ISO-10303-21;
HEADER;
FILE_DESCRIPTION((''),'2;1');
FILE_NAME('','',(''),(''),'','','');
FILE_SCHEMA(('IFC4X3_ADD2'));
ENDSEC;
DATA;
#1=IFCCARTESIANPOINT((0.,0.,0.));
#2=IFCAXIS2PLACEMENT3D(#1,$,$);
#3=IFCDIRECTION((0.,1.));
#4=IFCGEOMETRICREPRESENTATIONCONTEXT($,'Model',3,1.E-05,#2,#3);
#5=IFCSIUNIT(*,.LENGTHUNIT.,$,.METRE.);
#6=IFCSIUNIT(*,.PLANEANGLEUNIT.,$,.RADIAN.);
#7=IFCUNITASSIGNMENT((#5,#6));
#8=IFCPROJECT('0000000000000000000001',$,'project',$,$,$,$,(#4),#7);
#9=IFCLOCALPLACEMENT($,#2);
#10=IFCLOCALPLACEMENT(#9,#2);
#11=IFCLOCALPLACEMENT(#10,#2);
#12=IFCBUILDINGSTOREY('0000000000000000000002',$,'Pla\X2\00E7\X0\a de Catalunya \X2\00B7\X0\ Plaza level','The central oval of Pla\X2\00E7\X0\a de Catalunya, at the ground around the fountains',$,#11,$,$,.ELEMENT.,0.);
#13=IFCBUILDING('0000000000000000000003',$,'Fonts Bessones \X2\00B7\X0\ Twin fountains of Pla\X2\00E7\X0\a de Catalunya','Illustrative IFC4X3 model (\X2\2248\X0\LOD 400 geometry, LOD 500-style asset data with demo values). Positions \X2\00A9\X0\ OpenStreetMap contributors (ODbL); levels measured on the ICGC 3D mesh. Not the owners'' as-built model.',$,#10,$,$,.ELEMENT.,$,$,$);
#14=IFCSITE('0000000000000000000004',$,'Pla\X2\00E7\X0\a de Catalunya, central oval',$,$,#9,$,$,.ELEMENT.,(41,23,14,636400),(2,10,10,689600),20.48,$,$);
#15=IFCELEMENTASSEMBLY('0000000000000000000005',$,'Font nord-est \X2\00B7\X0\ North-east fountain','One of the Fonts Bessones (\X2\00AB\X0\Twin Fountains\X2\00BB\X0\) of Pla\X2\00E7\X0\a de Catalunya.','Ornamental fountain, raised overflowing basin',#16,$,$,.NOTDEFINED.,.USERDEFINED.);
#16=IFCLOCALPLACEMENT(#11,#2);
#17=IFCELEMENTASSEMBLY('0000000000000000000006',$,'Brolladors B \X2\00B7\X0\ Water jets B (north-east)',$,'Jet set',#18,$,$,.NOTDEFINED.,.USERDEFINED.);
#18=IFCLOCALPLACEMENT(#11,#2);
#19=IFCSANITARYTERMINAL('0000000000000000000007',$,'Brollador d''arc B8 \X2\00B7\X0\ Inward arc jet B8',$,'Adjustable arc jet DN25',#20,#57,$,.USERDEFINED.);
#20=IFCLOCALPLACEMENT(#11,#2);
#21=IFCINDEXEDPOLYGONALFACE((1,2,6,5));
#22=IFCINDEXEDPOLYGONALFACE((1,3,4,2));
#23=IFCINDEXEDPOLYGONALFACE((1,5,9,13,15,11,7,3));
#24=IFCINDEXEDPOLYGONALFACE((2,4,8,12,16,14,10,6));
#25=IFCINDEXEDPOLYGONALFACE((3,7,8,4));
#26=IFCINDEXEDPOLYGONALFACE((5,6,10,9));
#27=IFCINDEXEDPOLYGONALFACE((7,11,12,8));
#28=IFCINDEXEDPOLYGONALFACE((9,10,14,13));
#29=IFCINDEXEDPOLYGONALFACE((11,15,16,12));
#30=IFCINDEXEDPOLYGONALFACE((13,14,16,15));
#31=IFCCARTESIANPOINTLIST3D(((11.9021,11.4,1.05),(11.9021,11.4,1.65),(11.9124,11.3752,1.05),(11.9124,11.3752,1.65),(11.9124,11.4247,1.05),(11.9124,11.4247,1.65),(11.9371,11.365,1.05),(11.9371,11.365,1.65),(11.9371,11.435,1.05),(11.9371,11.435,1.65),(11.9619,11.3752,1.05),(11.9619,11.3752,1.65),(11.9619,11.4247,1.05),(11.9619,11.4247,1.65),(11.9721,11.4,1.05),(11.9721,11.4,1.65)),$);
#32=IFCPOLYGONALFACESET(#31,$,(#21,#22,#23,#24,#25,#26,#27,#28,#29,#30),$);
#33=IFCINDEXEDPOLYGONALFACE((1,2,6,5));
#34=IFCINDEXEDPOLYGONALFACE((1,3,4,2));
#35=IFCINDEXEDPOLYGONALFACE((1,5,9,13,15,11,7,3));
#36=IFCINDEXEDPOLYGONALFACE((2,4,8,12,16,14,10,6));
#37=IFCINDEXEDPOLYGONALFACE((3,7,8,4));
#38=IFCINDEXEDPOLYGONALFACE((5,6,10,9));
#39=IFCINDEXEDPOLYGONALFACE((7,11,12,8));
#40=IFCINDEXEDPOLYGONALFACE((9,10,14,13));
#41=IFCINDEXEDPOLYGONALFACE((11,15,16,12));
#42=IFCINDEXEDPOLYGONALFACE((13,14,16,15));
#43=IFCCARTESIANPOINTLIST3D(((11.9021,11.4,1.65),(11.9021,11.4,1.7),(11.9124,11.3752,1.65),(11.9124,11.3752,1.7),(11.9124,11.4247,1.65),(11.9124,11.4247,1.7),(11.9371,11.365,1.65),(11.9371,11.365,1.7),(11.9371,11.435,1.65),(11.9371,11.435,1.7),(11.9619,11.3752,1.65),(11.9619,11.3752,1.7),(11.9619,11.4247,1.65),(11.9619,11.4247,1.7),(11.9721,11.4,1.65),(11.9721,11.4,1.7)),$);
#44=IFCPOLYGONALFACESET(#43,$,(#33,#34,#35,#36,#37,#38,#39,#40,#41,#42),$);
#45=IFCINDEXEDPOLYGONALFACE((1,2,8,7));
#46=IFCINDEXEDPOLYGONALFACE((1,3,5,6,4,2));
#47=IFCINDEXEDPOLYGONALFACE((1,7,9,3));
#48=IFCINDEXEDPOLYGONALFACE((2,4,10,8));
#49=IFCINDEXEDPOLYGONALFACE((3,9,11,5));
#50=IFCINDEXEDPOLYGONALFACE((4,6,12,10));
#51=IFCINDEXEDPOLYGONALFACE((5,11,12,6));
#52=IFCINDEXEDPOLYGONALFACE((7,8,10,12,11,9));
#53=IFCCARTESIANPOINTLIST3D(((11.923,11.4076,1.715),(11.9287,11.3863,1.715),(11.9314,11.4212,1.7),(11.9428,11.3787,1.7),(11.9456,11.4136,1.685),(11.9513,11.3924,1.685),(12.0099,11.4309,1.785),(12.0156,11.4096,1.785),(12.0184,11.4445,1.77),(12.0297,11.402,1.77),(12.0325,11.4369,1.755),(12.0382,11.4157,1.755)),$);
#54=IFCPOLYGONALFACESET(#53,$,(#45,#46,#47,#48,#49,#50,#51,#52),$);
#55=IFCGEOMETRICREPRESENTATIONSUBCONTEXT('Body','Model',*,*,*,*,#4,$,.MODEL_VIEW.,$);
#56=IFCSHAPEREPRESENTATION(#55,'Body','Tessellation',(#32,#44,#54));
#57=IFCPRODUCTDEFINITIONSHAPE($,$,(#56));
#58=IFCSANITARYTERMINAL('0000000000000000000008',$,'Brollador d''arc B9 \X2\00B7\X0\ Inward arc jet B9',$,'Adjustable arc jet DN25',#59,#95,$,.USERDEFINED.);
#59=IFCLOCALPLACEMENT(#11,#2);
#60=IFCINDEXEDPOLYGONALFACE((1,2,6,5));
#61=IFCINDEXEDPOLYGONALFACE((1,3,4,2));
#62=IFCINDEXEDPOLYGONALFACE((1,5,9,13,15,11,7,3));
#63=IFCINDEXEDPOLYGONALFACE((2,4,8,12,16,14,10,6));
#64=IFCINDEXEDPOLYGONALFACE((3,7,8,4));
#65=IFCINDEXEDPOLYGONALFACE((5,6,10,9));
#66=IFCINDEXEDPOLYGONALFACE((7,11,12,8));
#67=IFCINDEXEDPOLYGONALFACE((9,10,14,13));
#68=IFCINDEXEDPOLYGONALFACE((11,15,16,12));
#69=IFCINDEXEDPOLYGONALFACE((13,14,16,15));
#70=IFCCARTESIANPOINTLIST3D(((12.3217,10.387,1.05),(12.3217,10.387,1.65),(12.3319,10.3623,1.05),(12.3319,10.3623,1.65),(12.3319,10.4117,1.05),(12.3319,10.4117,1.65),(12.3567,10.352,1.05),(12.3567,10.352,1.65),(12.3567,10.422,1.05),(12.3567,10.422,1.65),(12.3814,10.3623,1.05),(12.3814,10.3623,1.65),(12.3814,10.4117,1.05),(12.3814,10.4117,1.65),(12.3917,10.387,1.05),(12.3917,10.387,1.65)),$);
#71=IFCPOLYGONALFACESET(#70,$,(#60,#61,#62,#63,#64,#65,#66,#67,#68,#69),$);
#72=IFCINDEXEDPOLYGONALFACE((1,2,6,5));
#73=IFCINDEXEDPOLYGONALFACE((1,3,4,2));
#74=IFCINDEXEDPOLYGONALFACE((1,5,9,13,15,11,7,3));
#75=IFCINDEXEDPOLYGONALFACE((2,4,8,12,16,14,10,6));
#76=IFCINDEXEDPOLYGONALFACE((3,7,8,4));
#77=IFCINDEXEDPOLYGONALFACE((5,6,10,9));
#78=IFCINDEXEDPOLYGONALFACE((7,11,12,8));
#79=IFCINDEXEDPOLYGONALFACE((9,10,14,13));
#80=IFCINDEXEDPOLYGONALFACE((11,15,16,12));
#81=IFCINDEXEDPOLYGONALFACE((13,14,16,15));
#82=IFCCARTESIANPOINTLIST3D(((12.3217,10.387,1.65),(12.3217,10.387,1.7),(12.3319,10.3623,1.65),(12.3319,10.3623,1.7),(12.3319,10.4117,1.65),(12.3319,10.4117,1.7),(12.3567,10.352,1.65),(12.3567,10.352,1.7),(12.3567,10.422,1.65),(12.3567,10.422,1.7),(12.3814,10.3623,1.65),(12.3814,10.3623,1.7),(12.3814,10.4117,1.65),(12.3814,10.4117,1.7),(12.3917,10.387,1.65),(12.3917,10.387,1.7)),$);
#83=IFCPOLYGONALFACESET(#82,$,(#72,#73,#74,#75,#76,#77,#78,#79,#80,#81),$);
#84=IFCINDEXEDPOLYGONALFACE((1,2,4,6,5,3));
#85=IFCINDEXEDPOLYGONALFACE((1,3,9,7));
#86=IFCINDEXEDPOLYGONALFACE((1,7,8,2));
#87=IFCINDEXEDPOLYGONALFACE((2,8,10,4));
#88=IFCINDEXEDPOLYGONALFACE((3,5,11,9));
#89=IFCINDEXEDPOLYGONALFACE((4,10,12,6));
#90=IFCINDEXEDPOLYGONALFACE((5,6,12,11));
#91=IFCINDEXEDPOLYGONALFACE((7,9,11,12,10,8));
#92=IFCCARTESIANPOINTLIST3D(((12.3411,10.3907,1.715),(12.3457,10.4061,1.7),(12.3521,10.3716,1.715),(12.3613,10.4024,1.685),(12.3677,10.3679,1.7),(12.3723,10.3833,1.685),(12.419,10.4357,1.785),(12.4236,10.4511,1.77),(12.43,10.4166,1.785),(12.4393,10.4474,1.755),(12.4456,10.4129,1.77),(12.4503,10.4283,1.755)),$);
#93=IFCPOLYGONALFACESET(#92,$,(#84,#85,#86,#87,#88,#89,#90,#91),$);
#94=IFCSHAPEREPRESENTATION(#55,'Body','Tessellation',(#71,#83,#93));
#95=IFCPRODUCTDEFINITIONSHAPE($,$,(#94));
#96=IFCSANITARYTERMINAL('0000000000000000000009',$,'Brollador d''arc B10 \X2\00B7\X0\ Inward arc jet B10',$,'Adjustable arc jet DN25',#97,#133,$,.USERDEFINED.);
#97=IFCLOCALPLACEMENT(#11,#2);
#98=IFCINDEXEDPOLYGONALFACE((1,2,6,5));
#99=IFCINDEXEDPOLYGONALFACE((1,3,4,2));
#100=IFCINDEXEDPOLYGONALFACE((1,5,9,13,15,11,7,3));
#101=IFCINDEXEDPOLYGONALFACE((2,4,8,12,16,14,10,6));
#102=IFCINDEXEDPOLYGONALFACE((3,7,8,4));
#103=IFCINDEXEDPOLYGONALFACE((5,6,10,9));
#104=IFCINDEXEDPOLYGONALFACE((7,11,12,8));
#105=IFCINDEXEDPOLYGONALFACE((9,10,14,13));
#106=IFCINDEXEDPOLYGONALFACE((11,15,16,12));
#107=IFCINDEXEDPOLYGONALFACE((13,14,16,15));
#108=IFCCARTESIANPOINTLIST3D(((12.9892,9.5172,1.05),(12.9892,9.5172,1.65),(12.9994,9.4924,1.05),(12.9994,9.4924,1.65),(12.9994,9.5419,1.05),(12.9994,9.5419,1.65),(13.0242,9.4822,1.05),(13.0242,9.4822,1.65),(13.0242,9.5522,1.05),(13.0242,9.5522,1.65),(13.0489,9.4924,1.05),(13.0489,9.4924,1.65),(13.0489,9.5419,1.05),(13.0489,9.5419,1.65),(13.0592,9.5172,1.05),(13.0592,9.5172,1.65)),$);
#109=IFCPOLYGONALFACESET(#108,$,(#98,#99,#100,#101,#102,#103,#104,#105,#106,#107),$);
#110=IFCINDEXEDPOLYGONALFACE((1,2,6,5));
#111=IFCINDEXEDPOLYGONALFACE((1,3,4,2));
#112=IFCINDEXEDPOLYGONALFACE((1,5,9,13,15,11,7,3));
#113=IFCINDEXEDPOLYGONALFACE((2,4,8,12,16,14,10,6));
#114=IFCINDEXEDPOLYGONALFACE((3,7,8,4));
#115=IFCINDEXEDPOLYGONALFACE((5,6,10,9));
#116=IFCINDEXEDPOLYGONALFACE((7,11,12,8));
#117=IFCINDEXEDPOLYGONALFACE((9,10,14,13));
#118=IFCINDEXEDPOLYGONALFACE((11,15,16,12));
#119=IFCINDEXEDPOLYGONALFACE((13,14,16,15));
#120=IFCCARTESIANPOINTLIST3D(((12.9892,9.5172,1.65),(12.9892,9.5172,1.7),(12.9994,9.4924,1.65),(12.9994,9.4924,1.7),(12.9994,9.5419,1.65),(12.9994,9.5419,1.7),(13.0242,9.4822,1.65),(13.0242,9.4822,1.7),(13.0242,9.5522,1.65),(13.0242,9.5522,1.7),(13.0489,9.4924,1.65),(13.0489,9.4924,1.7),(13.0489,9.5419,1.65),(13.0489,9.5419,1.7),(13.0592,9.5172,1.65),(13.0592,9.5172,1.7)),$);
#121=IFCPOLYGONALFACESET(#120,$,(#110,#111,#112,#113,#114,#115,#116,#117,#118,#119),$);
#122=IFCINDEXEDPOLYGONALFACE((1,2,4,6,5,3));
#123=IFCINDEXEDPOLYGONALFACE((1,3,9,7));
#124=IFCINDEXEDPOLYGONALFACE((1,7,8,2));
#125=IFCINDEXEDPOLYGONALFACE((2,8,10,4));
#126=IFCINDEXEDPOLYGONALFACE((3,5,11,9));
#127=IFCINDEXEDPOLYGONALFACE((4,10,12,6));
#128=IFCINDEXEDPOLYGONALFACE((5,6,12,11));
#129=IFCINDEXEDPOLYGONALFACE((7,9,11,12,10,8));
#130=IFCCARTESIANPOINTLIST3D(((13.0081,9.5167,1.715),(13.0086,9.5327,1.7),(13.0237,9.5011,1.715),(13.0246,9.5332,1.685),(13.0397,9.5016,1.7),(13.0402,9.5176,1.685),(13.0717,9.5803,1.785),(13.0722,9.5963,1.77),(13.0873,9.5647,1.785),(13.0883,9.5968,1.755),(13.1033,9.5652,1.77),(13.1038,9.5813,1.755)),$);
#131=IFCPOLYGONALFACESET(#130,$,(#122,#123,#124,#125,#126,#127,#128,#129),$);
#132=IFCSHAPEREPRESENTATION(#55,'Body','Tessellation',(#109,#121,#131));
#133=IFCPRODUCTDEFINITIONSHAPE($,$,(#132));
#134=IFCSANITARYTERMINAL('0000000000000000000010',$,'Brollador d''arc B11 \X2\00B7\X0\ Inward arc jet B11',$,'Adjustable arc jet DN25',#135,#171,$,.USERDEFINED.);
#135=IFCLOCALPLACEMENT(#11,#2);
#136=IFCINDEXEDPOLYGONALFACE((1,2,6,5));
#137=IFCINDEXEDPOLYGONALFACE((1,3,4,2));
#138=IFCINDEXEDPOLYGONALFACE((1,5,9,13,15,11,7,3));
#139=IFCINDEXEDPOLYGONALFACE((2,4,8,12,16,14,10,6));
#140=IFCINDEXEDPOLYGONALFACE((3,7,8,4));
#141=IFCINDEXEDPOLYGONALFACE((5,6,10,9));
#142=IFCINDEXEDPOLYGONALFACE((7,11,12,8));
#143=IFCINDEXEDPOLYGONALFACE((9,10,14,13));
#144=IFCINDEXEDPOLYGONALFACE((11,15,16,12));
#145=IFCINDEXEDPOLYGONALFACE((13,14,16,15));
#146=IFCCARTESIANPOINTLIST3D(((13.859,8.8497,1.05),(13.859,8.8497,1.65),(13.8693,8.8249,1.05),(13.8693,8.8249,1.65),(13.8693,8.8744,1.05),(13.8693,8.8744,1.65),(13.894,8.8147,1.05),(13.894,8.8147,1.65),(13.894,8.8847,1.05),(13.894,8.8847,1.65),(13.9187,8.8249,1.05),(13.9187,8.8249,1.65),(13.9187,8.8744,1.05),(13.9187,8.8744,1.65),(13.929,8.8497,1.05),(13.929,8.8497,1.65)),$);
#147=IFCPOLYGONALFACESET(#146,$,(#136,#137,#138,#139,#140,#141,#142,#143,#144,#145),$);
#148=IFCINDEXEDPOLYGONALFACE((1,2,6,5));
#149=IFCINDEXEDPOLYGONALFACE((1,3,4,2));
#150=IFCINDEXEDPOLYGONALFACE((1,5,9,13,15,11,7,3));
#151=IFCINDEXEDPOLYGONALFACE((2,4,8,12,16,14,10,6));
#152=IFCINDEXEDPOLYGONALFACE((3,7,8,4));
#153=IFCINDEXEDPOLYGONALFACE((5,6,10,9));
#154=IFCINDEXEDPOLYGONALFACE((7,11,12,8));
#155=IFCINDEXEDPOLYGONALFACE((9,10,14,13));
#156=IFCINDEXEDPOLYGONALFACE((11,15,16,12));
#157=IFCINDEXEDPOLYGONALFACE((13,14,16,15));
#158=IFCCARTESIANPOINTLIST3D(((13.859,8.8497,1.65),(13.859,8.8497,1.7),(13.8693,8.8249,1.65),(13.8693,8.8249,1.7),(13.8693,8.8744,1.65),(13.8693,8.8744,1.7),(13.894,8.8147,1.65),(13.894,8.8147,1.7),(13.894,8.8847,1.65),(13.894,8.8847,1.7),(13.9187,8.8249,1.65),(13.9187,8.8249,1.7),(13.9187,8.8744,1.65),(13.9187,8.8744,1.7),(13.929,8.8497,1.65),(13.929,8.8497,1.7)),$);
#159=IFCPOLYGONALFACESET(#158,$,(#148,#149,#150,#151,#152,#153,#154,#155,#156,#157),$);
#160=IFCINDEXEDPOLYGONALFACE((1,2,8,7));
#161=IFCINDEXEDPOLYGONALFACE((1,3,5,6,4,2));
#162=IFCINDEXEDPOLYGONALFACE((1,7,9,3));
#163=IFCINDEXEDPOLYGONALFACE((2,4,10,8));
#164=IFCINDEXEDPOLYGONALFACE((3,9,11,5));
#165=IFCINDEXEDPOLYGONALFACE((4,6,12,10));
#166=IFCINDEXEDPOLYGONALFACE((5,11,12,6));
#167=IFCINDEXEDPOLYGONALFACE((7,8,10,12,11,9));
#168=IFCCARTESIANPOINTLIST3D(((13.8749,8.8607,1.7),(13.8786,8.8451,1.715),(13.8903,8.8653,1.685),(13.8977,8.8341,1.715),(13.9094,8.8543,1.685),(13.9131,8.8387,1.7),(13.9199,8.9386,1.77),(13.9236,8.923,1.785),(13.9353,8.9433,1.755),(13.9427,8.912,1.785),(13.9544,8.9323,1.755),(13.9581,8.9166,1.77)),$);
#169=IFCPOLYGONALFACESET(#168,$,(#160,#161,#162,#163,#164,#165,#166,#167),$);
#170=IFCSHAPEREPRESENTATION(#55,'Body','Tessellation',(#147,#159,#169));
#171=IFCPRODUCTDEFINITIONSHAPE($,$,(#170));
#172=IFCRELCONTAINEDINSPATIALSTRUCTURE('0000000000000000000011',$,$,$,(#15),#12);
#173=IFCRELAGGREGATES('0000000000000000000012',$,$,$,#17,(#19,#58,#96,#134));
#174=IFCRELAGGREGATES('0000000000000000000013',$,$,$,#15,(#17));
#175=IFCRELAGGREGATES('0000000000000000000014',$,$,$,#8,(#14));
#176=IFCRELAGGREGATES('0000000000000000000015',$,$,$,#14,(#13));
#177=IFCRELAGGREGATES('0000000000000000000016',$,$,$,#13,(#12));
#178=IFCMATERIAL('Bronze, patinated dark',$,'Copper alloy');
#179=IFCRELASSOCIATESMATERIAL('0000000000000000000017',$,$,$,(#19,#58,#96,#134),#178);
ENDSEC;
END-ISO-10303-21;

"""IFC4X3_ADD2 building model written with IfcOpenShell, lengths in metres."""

from ifc_helpers import new_model, si_unit, direction, frame, origin, place, context, subcontext, project, spatial, polyline, outline, extrude, material, element, aggregate, save


model = new_model("IFC4X3_ADD2")

# Units and contexts
model_context = context("Model", 3, precision=1e-05, world=origin(), true_north=direction((0.0, 1.0)))
body_context = subcontext(model_context, "Body", "Model", "MODEL_VIEW")
ifc_project = project(units=[si_unit("LENGTHUNIT", "METRE"), si_unit("PLANEANGLEUNIT", "RADIAN")], contexts=[model_context])

# Site, building, storey
site_placement = place(None, origin())
site = spatial("IfcSite", under=ifc_project, at=site_placement, Name="Plaça de Catalunya, central oval", CompositionType="ELEMENT", RefLatitude=(41, 23, 14, 636400), RefLongitude=(2, 10, 10, 689600), RefElevation=20.48)
building_placement = place(site_placement, origin())
building = spatial("IfcBuilding", under=site, at=building_placement, Name="Fonts Bessones · Twin fountains of Plaça de Catalunya", Description="Illustrative IFC4X3 model (≈LOD 400 geometry, LOD 500-style asset data with demo values). Positions © OpenStreetMap contributors (ODbL); levels measured on the ICGC 3D mesh. Not the owners' as-built model.", CompositionType="ELEMENT")
storey_placement = place(building_placement, origin())
storey = spatial("IfcBuildingStorey", under=building, at=storey_placement, Name="Plaça de Catalunya · Plaza level", Description="The central oval of Plaça de Catalunya, at the ground around the fountains", CompositionType="ELEMENT", Elevation=0.0)

# Element assemblies, sanitary terminals
assembly_1_placement = place(building_placement, origin())
assembly_1 = element("IfcElementAssembly", 1, at=assembly_1_placement, inside=storey, Name="Font nord-est · North-east fountain", Description="One of the Fonts Bessones («Twin Fountains») of Plaça de Catalunya.", ObjectType="Ornamental fountain, raised overflowing basin", AssemblyPlace="NOTDEFINED", PredefinedType="USERDEFINED")
assembly_2_placement = place(building_placement, origin())
assembly_2 = element("IfcElementAssembly", 2, at=assembly_2_placement, Name="Brolladors B · Water jets B (north-east)", ObjectType="Jet set", AssemblyPlace="NOTDEFINED", PredefinedType="USERDEFINED")
ifc_material_1 = material(Name="Bronze, patinated dark", Category="Copper alloy")
sanitary_terminal_1_placement = place(building_placement, origin())
sanitary_terminal_1 = element("IfcSanitaryTerminal", 3, at=sanitary_terminal_1_placement, material=ifc_material_1, Name="Brollador d'arc B8 · Inward arc jet B8", ObjectType="Adjustable arc jet DN25", PredefinedType="USERDEFINED", context=body_context, shape_type="SweptSolid", body=[
    extrude(outline(polyline([(11.9721, 11.4), (11.9619, 11.4247), (11.9371, 11.435), (11.9124, 11.4247), (11.9021, 11.4), (11.9124, 11.3752), (11.9371, 11.365), (11.9619, 11.3752), (11.9721, 11.4)])), frame((0.0, 0.0, 1.05)), (0.0, 0.0, 1.0), 0.6),
    extrude(outline(polyline([(11.9721, 11.4), (11.9619, 11.4247), (11.9371, 11.435), (11.9124, 11.4247), (11.9021, 11.4), (11.9124, 11.3752), (11.9371, 11.365), (11.9619, 11.3752), (11.9721, 11.4)])), frame((0.0, 0.0, 1.65)), (0.0, 0.0, 1.0), 0.05),
    extrude(outline(polyline([(0.022, 0.0), (0.011, 0.0191), (-0.011, 0.0191), (-0.022, 0.0), (-0.011, -0.0191), (0.011, -0.0191), (0.022, 0.0)])), frame((11.9371, 11.4, 1.7), z_axis=(0.762456, 0.204299, 0.613941), x_axis=(0.258819, -0.965926, 0.0)), (0.0, 0.0, 1.0), 0.114),
])
sanitary_terminal_2_placement = place(building_placement, origin())
sanitary_terminal_2 = element("IfcSanitaryTerminal", 4, at=sanitary_terminal_2_placement, material=ifc_material_1, Name="Brollador d'arc B9 · Inward arc jet B9", ObjectType="Adjustable arc jet DN25", PredefinedType="USERDEFINED", context=body_context, shape_type="SweptSolid", body=[
    extrude(outline(polyline([(12.3917, 10.387), (12.3814, 10.4117), (12.3567, 10.422), (12.3319, 10.4117), (12.3217, 10.387), (12.3319, 10.3623), (12.3567, 10.352), (12.3814, 10.3623), (12.3917, 10.387)])), frame((0.0, 0.0, 1.05)), (0.0, 0.0, 1.0), 0.6),
    extrude(outline(polyline([(12.3917, 10.387), (12.3814, 10.4117), (12.3567, 10.422), (12.3319, 10.4117), (12.3217, 10.387), (12.3319, 10.3623), (12.3567, 10.352), (12.3814, 10.3623), (12.3917, 10.387)])), frame((0.0, 0.0, 1.65)), (0.0, 0.0, 1.0), 0.05),
    extrude(outline(polyline([(0.022, 0.0), (0.011, 0.0191), (-0.011, 0.0191), (-0.022, 0.0), (-0.011, -0.0191), (0.011, -0.0191), (0.022, 0.0)])), frame((12.3567, 10.387, 1.7), z_axis=(0.683599, 0.394676, 0.613941), x_axis=(0.5, -0.866025, 0.0)), (0.0, 0.0, 1.0), 0.114),
])
sanitary_terminal_3_placement = place(building_placement, origin())
sanitary_terminal_3 = element("IfcSanitaryTerminal", 5, at=sanitary_terminal_3_placement, material=ifc_material_1, Name="Brollador d'arc B10 · Inward arc jet B10", ObjectType="Adjustable arc jet DN25", PredefinedType="USERDEFINED", context=body_context, shape_type="SweptSolid", body=[
    extrude(outline(polyline([(13.0592, 9.5172), (13.0489, 9.5419), (13.0242, 9.5522), (12.9994, 9.5419), (12.9892, 9.5172), (12.9994, 9.4924), (13.0242, 9.4822), (13.0489, 9.4924), (13.0592, 9.5172)])), frame((0.0, 0.0, 1.05)), (0.0, 0.0, 1.0), 0.6),
    extrude(outline(polyline([(13.0592, 9.5172), (13.0489, 9.5419), (13.0242, 9.5522), (12.9994, 9.5419), (12.9892, 9.5172), (12.9994, 9.4924), (13.0242, 9.4822), (13.0489, 9.4924), (13.0592, 9.5172)])), frame((0.0, 0.0, 1.65)), (0.0, 0.0, 1.0), 0.05),
    extrude(outline(polyline([(0.022, 0.0), (0.011, 0.0191), (-0.011, 0.0191), (-0.022, 0.0), (-0.011, -0.0191), (0.011, -0.0191), (0.022, 0.0)])), frame((13.0242, 9.5172, 1.7), z_axis=(0.558156, 0.558156, 0.613941), x_axis=(0.707107, -0.707107, 0.0)), (0.0, 0.0, 1.0), 0.114),
])
sanitary_terminal_4_placement = place(building_placement, origin())
sanitary_terminal_4 = element("IfcSanitaryTerminal", 6, at=sanitary_terminal_4_placement, material=ifc_material_1, Name="Brollador d'arc B11 · Inward arc jet B11", ObjectType="Adjustable arc jet DN25", PredefinedType="USERDEFINED", context=body_context, shape_type="SweptSolid", body=[
    extrude(outline(polyline([(13.929, 8.8497), (13.9187, 8.8744), (13.894, 8.8847), (13.8693, 8.8744), (13.859, 8.8497), (13.8693, 8.8249), (13.894, 8.8147), (13.9187, 8.8249), (13.929, 8.8497)])), frame((0.0, 0.0, 1.05)), (0.0, 0.0, 1.0), 0.6),
    extrude(outline(polyline([(13.929, 8.8497), (13.9187, 8.8744), (13.894, 8.8847), (13.8693, 8.8744), (13.859, 8.8497), (13.8693, 8.8249), (13.894, 8.8147), (13.9187, 8.8249), (13.929, 8.8497)])), frame((0.0, 0.0, 1.65)), (0.0, 0.0, 1.0), 0.05),
    extrude(outline(polyline([(0.022, 0.0), (0.011, 0.0191), (-0.011, 0.0191), (-0.022, 0.0), (-0.011, -0.0191), (0.011, -0.0191), (0.022, 0.0)])), frame((13.894, 8.8497, 1.7), z_axis=(0.394676, 0.683599, 0.613941), x_axis=(0.866025, -0.5, 0.0)), (0.0, 0.0, 1.0), 0.114),
])
aggregate(assembly_2, [sanitary_terminal_1, sanitary_terminal_2, sanitary_terminal_3, sanitary_terminal_4])
aggregate(assembly_1, [assembly_2])

save(model, "model.ifc")
